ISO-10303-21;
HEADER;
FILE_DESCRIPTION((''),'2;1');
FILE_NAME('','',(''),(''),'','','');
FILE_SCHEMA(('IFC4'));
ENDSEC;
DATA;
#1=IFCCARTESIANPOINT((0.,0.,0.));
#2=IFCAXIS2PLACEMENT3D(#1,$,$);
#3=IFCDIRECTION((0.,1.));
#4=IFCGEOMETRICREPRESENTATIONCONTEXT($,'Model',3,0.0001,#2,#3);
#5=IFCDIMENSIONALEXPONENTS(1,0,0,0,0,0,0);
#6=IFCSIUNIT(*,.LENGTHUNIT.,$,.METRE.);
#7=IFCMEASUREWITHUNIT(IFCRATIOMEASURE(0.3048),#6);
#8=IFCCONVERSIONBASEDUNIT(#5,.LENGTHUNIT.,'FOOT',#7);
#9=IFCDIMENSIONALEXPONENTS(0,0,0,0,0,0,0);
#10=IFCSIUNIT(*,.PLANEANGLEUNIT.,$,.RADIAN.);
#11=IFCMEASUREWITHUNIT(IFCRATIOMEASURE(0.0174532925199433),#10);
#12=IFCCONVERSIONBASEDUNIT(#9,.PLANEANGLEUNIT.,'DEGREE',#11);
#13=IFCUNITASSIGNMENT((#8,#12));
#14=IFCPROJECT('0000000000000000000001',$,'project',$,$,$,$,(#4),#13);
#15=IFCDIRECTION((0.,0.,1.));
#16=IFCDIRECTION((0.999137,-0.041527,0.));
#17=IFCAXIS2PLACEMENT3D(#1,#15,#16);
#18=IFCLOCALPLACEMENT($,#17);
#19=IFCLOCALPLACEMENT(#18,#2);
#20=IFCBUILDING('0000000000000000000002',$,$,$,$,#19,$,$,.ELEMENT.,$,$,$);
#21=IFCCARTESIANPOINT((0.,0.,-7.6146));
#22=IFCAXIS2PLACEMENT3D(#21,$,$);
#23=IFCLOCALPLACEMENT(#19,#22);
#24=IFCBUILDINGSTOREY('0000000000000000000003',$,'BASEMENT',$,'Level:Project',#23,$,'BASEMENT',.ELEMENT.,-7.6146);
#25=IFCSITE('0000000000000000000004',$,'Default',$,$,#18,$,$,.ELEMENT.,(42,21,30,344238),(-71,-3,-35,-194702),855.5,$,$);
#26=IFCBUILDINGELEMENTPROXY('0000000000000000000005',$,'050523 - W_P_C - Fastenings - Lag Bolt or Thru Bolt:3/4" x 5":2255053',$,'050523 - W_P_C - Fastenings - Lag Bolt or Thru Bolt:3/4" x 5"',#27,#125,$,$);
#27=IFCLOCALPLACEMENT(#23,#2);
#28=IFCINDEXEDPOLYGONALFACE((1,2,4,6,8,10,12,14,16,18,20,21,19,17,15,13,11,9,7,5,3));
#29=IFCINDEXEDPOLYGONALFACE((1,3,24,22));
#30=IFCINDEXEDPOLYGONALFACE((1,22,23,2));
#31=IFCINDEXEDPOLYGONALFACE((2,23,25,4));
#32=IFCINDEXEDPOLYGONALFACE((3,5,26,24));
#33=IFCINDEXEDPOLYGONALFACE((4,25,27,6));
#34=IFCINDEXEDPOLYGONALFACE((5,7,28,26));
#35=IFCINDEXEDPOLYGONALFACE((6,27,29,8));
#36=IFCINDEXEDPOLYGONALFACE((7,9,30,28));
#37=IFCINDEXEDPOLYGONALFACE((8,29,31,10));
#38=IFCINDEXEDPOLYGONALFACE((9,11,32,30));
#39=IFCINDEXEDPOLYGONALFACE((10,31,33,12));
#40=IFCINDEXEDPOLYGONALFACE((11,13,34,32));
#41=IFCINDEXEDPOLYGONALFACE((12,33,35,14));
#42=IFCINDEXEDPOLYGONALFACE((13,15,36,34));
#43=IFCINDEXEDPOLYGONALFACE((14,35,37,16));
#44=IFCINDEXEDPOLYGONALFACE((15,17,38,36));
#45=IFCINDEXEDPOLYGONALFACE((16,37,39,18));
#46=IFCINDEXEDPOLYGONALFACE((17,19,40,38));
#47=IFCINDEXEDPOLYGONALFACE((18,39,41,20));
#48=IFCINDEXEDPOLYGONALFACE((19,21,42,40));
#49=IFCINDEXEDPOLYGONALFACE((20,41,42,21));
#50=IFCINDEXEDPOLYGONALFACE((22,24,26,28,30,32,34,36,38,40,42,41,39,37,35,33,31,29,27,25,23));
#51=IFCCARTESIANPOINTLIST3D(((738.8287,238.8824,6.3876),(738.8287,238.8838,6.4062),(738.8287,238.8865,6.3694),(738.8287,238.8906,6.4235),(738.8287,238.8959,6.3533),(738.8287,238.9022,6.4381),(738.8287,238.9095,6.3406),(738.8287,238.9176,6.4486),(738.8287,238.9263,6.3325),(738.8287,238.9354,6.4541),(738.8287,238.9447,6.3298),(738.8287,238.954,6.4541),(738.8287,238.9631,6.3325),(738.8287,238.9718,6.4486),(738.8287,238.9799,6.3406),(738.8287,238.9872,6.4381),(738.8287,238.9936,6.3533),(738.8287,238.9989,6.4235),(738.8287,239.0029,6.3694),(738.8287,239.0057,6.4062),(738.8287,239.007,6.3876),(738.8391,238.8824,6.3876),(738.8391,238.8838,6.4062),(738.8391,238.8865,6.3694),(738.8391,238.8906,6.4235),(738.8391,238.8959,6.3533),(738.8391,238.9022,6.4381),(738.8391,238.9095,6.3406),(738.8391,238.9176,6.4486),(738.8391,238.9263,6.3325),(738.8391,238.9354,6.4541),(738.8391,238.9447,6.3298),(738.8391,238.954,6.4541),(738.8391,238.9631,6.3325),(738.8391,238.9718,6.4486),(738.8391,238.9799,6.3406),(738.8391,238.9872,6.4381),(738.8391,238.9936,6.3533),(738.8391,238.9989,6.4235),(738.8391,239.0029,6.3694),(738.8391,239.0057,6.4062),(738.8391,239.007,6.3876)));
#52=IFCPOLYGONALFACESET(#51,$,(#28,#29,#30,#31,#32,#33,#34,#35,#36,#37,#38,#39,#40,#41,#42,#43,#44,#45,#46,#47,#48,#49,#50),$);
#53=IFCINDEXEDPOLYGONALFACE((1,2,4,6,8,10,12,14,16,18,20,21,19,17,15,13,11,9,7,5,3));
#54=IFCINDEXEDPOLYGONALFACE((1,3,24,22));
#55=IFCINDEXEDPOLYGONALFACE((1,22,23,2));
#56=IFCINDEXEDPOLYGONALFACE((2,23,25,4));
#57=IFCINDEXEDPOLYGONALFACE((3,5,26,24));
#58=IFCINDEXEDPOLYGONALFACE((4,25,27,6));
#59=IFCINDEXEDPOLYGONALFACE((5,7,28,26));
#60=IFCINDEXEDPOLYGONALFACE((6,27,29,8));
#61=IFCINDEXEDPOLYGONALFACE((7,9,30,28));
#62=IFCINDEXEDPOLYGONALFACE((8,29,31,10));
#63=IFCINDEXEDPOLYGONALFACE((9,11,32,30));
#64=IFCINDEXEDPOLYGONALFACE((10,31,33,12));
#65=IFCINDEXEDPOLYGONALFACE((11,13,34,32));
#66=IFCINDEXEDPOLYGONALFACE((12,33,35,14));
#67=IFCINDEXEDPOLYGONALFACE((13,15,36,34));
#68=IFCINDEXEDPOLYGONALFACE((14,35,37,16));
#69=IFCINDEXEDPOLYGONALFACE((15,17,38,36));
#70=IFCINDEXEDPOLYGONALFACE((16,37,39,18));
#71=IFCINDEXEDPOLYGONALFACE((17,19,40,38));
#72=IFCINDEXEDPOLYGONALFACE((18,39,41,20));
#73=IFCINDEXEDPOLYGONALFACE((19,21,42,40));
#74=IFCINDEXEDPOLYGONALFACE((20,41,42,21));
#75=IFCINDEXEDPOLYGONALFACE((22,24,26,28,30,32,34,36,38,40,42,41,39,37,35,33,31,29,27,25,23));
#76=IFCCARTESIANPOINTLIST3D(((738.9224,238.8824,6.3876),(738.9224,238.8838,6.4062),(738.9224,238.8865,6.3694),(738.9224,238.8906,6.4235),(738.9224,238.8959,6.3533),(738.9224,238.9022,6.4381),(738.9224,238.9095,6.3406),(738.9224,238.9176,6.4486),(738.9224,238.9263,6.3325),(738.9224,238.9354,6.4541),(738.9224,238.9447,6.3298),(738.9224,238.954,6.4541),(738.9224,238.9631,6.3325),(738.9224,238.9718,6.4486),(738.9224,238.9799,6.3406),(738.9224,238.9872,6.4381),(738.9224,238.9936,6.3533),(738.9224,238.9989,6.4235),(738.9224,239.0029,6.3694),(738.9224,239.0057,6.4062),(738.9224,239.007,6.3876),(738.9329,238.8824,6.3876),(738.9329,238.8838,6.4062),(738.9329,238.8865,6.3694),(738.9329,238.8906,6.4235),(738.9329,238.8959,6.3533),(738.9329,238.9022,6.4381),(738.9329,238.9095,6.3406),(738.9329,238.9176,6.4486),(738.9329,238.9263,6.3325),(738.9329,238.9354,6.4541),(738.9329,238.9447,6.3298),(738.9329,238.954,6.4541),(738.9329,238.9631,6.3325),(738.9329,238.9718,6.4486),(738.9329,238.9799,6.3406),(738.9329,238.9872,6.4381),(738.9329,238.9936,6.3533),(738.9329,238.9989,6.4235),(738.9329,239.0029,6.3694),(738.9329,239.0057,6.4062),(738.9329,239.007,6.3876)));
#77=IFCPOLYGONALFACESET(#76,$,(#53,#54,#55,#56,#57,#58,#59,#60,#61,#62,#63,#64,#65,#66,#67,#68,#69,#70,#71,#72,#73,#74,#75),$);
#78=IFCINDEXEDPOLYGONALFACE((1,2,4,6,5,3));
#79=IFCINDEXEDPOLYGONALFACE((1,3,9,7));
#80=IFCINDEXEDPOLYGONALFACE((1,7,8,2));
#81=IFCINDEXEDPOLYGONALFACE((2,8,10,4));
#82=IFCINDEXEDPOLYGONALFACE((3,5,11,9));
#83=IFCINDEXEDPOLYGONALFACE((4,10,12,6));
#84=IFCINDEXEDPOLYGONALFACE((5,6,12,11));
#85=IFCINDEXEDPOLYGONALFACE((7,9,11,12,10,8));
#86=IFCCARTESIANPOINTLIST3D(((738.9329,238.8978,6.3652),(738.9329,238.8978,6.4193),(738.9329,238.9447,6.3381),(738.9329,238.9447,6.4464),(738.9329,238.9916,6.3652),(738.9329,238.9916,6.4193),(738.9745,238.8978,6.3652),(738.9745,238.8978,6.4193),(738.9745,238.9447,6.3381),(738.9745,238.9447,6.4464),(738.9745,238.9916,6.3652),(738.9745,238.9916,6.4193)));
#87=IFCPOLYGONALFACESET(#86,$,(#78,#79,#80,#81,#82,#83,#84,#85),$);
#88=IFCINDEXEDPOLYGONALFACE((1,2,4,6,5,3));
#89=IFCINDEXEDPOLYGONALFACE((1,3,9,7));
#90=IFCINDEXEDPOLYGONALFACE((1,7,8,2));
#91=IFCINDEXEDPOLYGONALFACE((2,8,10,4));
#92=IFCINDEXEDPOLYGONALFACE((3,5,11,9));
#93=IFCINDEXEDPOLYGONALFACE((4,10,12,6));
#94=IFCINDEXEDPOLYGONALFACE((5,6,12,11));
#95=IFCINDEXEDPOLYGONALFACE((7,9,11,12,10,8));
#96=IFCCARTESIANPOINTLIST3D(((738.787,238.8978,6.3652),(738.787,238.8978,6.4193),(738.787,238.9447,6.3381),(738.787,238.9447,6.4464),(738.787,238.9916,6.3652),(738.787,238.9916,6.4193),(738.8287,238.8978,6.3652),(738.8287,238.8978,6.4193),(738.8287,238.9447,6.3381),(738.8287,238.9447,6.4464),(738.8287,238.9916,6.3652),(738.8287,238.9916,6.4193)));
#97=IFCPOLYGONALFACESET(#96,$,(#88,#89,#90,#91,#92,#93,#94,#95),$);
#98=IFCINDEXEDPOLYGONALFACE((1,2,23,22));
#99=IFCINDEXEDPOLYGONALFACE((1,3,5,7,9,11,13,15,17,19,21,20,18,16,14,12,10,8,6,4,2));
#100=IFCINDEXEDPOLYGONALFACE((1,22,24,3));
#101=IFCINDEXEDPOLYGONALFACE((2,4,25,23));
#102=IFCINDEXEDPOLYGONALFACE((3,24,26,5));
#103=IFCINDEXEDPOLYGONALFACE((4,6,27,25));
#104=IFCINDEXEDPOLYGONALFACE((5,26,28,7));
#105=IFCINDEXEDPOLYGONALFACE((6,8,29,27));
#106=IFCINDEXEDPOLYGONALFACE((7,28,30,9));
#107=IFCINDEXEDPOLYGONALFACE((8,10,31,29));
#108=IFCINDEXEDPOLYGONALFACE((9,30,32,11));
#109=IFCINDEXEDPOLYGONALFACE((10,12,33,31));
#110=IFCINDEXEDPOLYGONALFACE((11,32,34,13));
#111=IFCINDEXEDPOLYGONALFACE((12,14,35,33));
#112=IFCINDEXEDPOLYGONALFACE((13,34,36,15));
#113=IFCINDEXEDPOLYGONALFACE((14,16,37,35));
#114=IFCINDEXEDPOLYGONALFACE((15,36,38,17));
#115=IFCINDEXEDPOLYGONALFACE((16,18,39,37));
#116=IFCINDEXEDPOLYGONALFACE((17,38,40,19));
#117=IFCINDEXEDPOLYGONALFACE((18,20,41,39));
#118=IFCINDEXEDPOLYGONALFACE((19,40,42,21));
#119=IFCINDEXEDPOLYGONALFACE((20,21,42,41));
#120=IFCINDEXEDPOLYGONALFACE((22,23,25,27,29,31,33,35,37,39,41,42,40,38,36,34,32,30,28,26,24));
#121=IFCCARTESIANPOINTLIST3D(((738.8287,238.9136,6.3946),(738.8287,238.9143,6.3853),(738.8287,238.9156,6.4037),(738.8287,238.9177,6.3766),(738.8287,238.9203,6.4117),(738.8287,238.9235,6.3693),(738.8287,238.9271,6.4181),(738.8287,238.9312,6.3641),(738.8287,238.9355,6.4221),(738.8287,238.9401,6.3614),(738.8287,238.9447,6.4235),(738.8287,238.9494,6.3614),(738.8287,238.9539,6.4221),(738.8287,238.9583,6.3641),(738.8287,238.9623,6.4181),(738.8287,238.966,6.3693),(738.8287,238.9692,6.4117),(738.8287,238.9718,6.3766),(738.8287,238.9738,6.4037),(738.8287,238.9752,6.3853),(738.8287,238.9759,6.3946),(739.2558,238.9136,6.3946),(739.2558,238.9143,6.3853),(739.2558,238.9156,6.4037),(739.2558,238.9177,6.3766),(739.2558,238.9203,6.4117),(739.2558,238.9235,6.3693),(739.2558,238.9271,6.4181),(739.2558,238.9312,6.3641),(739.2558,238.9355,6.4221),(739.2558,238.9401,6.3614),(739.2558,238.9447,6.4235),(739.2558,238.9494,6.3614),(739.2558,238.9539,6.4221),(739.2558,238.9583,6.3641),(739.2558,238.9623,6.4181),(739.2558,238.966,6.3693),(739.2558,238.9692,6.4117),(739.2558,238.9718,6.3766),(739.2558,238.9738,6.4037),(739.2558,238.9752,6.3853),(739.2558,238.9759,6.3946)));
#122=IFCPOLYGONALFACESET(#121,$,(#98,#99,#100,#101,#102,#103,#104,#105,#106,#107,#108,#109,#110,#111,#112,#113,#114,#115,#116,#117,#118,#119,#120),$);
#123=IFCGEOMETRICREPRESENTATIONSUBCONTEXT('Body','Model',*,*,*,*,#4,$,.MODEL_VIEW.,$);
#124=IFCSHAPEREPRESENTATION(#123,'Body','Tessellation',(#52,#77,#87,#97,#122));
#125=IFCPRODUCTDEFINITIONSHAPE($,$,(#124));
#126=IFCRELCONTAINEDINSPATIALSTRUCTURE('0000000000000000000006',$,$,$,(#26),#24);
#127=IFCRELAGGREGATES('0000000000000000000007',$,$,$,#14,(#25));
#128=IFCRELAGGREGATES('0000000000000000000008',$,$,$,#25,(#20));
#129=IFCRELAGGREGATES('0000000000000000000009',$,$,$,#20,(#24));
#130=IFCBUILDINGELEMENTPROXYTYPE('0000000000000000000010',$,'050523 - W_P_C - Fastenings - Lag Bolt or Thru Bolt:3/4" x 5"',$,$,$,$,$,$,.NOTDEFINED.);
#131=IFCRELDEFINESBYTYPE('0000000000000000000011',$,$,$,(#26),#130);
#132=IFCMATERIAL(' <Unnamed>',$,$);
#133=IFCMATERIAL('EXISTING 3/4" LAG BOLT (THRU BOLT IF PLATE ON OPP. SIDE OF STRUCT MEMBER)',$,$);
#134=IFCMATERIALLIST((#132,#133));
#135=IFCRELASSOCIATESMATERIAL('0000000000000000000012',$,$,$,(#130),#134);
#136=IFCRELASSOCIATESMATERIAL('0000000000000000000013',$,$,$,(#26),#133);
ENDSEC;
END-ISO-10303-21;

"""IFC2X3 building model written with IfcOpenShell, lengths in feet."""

from ifc_helpers import new_model, entity, si_unit, converted_unit, direction, frame, frame_2d, origin, place, context, subcontext, project, spatial, polyline, circle, outline, extrude, source, transform, mapped, material, material_list, type_object, type_shapes, element, save


model = new_model("IFC2X3")

# Units and contexts
model_context = context("Model", 3, precision=0.0001, world=origin(), true_north=direction((0.0, 1.0)))
body_context = subcontext(model_context, "Body", "Model", "MODEL_VIEW")
ifc_project = project(units=[converted_unit("LENGTHUNIT", "FOOT", entity("IfcRatioMeasure", 0.3048), si_unit("LENGTHUNIT", "METRE"), dimensions=[1, 0, 0, 0, 0, 0, 0]), converted_unit("PLANEANGLEUNIT", "DEGREE", entity("IfcRatioMeasure", 0.0174532925199433), si_unit("PLANEANGLEUNIT", "RADIAN"), dimensions=[0, 0, 0, 0, 0, 0, 0])], contexts=[model_context])

# Site, building, storey
site_placement = place(None, frame((0.0, 0.0, 0.0), z_axis=(0.0, 0.0, 1.0), x_axis=(0.999137, -0.041527, 0.0)))
site = spatial("IfcSite", under=ifc_project, at=site_placement, Name="Default", CompositionType="ELEMENT", RefLatitude=(42, 21, 30, 344238), RefLongitude=(-71, -3, -35, -194702), RefElevation=855.5)
building_placement = place(site_placement, origin())
building = spatial("IfcBuilding", under=site, at=building_placement, CompositionType="ELEMENT")
storey_placement = place(building_placement, frame((0.0, 0.0, -7.6146)))
storey = spatial("IfcBuildingStorey", under=building, at=storey_placement, Name="BASEMENT", ObjectType="Level:Project", LongName="BASEMENT", CompositionType="ELEMENT", Elevation=-7.6146)

# Building element proxy
ifc_material_1 = material(Name="EXISTING 3/4\" LAG BOLT (THRU BOLT IF PLATE ON OPP. SIDE OF STRUCT MEMBER)")
ifc_material_2 = material(Name=" <Unnamed>")
ifc_material_list_1 = material_list([ifc_material_2, ifc_material_1])
building_element_proxy_type_1 = type_object("IfcBuildingElementProxyType", Name="050523 - W_P_C - Fastenings - Lag Bolt or Thru Bolt:3/4\" x 5\"", PredefinedType="NOTDEFINED", material=ifc_material_list_1)
shared_shape_1 = source(origin(), body_context, "Body", "SweptSolid", [
    extrude(circle(Radius=0.0625, at=frame_2d((0.0, 0.0), x_axis=(1.0, 0.0))), frame((0.0, 0.0, 0.0), z_axis=(0.0, 0.0, 1.0), x_axis=(0.0, -1.0, 0.0)), (0.0, 0.0, 1.0), 0.0104),
    extrude(circle(Radius=0.0625, at=frame_2d((0.0, 0.0), x_axis=(1.0, 0.0))), frame((0.0, 0.0, -0.0938), z_axis=(0.0, 0.0, 1.0), x_axis=(0.0, -1.0, 0.0)), (0.0, 0.0, 1.0), 0.0104),
    extrude(outline(polyline([(-0.0271, -0.0469), (0.0271, -0.0469), (0.0541, 0.0), (0.0271, 0.0469), (-0.0271, 0.0469), (-0.0541, 0.0), (-0.0271, -0.0469)])), frame((0.0, 0.0, -0.1354), z_axis=(0.0, 0.0, 1.0), x_axis=(0.866025, -0.5, 0.0)), (0.0, 0.0, 1.0), 0.0417),
    extrude(outline(polyline([(-0.0271, -0.0469), (0.0271, -0.0469), (0.0541, 0.0), (0.0271, 0.0469), (-0.0271, 0.0469), (-0.0541, 0.0), (-0.0271, -0.0469)])), frame((0.0, 0.0, 0.0104), z_axis=(0.0, 0.0, 1.0), x_axis=(0.0, -1.0, 0.0)), (0.0, 0.0, 1.0), 0.0417),
    extrude(circle(Radius=0.0312, at=frame_2d((0.0, 0.0), x_axis=(1.0, 0.0))), frame((0.0, 0.0, -0.4167), z_axis=(0.0, 0.0, 1.0), x_axis=(0.0, 1.0, 0.0)), (0.0, 0.0, 1.0), 0.4271),
])
type_shapes(building_element_proxy_type_1, [shared_shape_1])
for number, where, z_axis, x_axis, name in (
    (1, (738.8391, 238.9447, 6.3923), (-1.0, 0.0, 0.0), (0.0, -1.0, 0.0), "050523 - W_P_C - Fastenings - Lag Bolt or Thru Bolt:3/4\" x 5\":2255053"),
):
    element("IfcBuildingElementProxy", number, at=place(storey_placement, frame(where, z_axis=z_axis, x_axis=x_axis)), inside=storey, type_object=building_element_proxy_type_1, material=ifc_material_1, Name=name, ObjectType="050523 - W_P_C - Fastenings - Lag Bolt or Thru Bolt:3/4\" x 5\"", context=body_context, shape_type="MappedRepresentation", body=[
        mapped(shared_shape_1, transform((0.0, 0.0, 0.0), scale=1.0)),
    ])

save(model, "model.ifc")
